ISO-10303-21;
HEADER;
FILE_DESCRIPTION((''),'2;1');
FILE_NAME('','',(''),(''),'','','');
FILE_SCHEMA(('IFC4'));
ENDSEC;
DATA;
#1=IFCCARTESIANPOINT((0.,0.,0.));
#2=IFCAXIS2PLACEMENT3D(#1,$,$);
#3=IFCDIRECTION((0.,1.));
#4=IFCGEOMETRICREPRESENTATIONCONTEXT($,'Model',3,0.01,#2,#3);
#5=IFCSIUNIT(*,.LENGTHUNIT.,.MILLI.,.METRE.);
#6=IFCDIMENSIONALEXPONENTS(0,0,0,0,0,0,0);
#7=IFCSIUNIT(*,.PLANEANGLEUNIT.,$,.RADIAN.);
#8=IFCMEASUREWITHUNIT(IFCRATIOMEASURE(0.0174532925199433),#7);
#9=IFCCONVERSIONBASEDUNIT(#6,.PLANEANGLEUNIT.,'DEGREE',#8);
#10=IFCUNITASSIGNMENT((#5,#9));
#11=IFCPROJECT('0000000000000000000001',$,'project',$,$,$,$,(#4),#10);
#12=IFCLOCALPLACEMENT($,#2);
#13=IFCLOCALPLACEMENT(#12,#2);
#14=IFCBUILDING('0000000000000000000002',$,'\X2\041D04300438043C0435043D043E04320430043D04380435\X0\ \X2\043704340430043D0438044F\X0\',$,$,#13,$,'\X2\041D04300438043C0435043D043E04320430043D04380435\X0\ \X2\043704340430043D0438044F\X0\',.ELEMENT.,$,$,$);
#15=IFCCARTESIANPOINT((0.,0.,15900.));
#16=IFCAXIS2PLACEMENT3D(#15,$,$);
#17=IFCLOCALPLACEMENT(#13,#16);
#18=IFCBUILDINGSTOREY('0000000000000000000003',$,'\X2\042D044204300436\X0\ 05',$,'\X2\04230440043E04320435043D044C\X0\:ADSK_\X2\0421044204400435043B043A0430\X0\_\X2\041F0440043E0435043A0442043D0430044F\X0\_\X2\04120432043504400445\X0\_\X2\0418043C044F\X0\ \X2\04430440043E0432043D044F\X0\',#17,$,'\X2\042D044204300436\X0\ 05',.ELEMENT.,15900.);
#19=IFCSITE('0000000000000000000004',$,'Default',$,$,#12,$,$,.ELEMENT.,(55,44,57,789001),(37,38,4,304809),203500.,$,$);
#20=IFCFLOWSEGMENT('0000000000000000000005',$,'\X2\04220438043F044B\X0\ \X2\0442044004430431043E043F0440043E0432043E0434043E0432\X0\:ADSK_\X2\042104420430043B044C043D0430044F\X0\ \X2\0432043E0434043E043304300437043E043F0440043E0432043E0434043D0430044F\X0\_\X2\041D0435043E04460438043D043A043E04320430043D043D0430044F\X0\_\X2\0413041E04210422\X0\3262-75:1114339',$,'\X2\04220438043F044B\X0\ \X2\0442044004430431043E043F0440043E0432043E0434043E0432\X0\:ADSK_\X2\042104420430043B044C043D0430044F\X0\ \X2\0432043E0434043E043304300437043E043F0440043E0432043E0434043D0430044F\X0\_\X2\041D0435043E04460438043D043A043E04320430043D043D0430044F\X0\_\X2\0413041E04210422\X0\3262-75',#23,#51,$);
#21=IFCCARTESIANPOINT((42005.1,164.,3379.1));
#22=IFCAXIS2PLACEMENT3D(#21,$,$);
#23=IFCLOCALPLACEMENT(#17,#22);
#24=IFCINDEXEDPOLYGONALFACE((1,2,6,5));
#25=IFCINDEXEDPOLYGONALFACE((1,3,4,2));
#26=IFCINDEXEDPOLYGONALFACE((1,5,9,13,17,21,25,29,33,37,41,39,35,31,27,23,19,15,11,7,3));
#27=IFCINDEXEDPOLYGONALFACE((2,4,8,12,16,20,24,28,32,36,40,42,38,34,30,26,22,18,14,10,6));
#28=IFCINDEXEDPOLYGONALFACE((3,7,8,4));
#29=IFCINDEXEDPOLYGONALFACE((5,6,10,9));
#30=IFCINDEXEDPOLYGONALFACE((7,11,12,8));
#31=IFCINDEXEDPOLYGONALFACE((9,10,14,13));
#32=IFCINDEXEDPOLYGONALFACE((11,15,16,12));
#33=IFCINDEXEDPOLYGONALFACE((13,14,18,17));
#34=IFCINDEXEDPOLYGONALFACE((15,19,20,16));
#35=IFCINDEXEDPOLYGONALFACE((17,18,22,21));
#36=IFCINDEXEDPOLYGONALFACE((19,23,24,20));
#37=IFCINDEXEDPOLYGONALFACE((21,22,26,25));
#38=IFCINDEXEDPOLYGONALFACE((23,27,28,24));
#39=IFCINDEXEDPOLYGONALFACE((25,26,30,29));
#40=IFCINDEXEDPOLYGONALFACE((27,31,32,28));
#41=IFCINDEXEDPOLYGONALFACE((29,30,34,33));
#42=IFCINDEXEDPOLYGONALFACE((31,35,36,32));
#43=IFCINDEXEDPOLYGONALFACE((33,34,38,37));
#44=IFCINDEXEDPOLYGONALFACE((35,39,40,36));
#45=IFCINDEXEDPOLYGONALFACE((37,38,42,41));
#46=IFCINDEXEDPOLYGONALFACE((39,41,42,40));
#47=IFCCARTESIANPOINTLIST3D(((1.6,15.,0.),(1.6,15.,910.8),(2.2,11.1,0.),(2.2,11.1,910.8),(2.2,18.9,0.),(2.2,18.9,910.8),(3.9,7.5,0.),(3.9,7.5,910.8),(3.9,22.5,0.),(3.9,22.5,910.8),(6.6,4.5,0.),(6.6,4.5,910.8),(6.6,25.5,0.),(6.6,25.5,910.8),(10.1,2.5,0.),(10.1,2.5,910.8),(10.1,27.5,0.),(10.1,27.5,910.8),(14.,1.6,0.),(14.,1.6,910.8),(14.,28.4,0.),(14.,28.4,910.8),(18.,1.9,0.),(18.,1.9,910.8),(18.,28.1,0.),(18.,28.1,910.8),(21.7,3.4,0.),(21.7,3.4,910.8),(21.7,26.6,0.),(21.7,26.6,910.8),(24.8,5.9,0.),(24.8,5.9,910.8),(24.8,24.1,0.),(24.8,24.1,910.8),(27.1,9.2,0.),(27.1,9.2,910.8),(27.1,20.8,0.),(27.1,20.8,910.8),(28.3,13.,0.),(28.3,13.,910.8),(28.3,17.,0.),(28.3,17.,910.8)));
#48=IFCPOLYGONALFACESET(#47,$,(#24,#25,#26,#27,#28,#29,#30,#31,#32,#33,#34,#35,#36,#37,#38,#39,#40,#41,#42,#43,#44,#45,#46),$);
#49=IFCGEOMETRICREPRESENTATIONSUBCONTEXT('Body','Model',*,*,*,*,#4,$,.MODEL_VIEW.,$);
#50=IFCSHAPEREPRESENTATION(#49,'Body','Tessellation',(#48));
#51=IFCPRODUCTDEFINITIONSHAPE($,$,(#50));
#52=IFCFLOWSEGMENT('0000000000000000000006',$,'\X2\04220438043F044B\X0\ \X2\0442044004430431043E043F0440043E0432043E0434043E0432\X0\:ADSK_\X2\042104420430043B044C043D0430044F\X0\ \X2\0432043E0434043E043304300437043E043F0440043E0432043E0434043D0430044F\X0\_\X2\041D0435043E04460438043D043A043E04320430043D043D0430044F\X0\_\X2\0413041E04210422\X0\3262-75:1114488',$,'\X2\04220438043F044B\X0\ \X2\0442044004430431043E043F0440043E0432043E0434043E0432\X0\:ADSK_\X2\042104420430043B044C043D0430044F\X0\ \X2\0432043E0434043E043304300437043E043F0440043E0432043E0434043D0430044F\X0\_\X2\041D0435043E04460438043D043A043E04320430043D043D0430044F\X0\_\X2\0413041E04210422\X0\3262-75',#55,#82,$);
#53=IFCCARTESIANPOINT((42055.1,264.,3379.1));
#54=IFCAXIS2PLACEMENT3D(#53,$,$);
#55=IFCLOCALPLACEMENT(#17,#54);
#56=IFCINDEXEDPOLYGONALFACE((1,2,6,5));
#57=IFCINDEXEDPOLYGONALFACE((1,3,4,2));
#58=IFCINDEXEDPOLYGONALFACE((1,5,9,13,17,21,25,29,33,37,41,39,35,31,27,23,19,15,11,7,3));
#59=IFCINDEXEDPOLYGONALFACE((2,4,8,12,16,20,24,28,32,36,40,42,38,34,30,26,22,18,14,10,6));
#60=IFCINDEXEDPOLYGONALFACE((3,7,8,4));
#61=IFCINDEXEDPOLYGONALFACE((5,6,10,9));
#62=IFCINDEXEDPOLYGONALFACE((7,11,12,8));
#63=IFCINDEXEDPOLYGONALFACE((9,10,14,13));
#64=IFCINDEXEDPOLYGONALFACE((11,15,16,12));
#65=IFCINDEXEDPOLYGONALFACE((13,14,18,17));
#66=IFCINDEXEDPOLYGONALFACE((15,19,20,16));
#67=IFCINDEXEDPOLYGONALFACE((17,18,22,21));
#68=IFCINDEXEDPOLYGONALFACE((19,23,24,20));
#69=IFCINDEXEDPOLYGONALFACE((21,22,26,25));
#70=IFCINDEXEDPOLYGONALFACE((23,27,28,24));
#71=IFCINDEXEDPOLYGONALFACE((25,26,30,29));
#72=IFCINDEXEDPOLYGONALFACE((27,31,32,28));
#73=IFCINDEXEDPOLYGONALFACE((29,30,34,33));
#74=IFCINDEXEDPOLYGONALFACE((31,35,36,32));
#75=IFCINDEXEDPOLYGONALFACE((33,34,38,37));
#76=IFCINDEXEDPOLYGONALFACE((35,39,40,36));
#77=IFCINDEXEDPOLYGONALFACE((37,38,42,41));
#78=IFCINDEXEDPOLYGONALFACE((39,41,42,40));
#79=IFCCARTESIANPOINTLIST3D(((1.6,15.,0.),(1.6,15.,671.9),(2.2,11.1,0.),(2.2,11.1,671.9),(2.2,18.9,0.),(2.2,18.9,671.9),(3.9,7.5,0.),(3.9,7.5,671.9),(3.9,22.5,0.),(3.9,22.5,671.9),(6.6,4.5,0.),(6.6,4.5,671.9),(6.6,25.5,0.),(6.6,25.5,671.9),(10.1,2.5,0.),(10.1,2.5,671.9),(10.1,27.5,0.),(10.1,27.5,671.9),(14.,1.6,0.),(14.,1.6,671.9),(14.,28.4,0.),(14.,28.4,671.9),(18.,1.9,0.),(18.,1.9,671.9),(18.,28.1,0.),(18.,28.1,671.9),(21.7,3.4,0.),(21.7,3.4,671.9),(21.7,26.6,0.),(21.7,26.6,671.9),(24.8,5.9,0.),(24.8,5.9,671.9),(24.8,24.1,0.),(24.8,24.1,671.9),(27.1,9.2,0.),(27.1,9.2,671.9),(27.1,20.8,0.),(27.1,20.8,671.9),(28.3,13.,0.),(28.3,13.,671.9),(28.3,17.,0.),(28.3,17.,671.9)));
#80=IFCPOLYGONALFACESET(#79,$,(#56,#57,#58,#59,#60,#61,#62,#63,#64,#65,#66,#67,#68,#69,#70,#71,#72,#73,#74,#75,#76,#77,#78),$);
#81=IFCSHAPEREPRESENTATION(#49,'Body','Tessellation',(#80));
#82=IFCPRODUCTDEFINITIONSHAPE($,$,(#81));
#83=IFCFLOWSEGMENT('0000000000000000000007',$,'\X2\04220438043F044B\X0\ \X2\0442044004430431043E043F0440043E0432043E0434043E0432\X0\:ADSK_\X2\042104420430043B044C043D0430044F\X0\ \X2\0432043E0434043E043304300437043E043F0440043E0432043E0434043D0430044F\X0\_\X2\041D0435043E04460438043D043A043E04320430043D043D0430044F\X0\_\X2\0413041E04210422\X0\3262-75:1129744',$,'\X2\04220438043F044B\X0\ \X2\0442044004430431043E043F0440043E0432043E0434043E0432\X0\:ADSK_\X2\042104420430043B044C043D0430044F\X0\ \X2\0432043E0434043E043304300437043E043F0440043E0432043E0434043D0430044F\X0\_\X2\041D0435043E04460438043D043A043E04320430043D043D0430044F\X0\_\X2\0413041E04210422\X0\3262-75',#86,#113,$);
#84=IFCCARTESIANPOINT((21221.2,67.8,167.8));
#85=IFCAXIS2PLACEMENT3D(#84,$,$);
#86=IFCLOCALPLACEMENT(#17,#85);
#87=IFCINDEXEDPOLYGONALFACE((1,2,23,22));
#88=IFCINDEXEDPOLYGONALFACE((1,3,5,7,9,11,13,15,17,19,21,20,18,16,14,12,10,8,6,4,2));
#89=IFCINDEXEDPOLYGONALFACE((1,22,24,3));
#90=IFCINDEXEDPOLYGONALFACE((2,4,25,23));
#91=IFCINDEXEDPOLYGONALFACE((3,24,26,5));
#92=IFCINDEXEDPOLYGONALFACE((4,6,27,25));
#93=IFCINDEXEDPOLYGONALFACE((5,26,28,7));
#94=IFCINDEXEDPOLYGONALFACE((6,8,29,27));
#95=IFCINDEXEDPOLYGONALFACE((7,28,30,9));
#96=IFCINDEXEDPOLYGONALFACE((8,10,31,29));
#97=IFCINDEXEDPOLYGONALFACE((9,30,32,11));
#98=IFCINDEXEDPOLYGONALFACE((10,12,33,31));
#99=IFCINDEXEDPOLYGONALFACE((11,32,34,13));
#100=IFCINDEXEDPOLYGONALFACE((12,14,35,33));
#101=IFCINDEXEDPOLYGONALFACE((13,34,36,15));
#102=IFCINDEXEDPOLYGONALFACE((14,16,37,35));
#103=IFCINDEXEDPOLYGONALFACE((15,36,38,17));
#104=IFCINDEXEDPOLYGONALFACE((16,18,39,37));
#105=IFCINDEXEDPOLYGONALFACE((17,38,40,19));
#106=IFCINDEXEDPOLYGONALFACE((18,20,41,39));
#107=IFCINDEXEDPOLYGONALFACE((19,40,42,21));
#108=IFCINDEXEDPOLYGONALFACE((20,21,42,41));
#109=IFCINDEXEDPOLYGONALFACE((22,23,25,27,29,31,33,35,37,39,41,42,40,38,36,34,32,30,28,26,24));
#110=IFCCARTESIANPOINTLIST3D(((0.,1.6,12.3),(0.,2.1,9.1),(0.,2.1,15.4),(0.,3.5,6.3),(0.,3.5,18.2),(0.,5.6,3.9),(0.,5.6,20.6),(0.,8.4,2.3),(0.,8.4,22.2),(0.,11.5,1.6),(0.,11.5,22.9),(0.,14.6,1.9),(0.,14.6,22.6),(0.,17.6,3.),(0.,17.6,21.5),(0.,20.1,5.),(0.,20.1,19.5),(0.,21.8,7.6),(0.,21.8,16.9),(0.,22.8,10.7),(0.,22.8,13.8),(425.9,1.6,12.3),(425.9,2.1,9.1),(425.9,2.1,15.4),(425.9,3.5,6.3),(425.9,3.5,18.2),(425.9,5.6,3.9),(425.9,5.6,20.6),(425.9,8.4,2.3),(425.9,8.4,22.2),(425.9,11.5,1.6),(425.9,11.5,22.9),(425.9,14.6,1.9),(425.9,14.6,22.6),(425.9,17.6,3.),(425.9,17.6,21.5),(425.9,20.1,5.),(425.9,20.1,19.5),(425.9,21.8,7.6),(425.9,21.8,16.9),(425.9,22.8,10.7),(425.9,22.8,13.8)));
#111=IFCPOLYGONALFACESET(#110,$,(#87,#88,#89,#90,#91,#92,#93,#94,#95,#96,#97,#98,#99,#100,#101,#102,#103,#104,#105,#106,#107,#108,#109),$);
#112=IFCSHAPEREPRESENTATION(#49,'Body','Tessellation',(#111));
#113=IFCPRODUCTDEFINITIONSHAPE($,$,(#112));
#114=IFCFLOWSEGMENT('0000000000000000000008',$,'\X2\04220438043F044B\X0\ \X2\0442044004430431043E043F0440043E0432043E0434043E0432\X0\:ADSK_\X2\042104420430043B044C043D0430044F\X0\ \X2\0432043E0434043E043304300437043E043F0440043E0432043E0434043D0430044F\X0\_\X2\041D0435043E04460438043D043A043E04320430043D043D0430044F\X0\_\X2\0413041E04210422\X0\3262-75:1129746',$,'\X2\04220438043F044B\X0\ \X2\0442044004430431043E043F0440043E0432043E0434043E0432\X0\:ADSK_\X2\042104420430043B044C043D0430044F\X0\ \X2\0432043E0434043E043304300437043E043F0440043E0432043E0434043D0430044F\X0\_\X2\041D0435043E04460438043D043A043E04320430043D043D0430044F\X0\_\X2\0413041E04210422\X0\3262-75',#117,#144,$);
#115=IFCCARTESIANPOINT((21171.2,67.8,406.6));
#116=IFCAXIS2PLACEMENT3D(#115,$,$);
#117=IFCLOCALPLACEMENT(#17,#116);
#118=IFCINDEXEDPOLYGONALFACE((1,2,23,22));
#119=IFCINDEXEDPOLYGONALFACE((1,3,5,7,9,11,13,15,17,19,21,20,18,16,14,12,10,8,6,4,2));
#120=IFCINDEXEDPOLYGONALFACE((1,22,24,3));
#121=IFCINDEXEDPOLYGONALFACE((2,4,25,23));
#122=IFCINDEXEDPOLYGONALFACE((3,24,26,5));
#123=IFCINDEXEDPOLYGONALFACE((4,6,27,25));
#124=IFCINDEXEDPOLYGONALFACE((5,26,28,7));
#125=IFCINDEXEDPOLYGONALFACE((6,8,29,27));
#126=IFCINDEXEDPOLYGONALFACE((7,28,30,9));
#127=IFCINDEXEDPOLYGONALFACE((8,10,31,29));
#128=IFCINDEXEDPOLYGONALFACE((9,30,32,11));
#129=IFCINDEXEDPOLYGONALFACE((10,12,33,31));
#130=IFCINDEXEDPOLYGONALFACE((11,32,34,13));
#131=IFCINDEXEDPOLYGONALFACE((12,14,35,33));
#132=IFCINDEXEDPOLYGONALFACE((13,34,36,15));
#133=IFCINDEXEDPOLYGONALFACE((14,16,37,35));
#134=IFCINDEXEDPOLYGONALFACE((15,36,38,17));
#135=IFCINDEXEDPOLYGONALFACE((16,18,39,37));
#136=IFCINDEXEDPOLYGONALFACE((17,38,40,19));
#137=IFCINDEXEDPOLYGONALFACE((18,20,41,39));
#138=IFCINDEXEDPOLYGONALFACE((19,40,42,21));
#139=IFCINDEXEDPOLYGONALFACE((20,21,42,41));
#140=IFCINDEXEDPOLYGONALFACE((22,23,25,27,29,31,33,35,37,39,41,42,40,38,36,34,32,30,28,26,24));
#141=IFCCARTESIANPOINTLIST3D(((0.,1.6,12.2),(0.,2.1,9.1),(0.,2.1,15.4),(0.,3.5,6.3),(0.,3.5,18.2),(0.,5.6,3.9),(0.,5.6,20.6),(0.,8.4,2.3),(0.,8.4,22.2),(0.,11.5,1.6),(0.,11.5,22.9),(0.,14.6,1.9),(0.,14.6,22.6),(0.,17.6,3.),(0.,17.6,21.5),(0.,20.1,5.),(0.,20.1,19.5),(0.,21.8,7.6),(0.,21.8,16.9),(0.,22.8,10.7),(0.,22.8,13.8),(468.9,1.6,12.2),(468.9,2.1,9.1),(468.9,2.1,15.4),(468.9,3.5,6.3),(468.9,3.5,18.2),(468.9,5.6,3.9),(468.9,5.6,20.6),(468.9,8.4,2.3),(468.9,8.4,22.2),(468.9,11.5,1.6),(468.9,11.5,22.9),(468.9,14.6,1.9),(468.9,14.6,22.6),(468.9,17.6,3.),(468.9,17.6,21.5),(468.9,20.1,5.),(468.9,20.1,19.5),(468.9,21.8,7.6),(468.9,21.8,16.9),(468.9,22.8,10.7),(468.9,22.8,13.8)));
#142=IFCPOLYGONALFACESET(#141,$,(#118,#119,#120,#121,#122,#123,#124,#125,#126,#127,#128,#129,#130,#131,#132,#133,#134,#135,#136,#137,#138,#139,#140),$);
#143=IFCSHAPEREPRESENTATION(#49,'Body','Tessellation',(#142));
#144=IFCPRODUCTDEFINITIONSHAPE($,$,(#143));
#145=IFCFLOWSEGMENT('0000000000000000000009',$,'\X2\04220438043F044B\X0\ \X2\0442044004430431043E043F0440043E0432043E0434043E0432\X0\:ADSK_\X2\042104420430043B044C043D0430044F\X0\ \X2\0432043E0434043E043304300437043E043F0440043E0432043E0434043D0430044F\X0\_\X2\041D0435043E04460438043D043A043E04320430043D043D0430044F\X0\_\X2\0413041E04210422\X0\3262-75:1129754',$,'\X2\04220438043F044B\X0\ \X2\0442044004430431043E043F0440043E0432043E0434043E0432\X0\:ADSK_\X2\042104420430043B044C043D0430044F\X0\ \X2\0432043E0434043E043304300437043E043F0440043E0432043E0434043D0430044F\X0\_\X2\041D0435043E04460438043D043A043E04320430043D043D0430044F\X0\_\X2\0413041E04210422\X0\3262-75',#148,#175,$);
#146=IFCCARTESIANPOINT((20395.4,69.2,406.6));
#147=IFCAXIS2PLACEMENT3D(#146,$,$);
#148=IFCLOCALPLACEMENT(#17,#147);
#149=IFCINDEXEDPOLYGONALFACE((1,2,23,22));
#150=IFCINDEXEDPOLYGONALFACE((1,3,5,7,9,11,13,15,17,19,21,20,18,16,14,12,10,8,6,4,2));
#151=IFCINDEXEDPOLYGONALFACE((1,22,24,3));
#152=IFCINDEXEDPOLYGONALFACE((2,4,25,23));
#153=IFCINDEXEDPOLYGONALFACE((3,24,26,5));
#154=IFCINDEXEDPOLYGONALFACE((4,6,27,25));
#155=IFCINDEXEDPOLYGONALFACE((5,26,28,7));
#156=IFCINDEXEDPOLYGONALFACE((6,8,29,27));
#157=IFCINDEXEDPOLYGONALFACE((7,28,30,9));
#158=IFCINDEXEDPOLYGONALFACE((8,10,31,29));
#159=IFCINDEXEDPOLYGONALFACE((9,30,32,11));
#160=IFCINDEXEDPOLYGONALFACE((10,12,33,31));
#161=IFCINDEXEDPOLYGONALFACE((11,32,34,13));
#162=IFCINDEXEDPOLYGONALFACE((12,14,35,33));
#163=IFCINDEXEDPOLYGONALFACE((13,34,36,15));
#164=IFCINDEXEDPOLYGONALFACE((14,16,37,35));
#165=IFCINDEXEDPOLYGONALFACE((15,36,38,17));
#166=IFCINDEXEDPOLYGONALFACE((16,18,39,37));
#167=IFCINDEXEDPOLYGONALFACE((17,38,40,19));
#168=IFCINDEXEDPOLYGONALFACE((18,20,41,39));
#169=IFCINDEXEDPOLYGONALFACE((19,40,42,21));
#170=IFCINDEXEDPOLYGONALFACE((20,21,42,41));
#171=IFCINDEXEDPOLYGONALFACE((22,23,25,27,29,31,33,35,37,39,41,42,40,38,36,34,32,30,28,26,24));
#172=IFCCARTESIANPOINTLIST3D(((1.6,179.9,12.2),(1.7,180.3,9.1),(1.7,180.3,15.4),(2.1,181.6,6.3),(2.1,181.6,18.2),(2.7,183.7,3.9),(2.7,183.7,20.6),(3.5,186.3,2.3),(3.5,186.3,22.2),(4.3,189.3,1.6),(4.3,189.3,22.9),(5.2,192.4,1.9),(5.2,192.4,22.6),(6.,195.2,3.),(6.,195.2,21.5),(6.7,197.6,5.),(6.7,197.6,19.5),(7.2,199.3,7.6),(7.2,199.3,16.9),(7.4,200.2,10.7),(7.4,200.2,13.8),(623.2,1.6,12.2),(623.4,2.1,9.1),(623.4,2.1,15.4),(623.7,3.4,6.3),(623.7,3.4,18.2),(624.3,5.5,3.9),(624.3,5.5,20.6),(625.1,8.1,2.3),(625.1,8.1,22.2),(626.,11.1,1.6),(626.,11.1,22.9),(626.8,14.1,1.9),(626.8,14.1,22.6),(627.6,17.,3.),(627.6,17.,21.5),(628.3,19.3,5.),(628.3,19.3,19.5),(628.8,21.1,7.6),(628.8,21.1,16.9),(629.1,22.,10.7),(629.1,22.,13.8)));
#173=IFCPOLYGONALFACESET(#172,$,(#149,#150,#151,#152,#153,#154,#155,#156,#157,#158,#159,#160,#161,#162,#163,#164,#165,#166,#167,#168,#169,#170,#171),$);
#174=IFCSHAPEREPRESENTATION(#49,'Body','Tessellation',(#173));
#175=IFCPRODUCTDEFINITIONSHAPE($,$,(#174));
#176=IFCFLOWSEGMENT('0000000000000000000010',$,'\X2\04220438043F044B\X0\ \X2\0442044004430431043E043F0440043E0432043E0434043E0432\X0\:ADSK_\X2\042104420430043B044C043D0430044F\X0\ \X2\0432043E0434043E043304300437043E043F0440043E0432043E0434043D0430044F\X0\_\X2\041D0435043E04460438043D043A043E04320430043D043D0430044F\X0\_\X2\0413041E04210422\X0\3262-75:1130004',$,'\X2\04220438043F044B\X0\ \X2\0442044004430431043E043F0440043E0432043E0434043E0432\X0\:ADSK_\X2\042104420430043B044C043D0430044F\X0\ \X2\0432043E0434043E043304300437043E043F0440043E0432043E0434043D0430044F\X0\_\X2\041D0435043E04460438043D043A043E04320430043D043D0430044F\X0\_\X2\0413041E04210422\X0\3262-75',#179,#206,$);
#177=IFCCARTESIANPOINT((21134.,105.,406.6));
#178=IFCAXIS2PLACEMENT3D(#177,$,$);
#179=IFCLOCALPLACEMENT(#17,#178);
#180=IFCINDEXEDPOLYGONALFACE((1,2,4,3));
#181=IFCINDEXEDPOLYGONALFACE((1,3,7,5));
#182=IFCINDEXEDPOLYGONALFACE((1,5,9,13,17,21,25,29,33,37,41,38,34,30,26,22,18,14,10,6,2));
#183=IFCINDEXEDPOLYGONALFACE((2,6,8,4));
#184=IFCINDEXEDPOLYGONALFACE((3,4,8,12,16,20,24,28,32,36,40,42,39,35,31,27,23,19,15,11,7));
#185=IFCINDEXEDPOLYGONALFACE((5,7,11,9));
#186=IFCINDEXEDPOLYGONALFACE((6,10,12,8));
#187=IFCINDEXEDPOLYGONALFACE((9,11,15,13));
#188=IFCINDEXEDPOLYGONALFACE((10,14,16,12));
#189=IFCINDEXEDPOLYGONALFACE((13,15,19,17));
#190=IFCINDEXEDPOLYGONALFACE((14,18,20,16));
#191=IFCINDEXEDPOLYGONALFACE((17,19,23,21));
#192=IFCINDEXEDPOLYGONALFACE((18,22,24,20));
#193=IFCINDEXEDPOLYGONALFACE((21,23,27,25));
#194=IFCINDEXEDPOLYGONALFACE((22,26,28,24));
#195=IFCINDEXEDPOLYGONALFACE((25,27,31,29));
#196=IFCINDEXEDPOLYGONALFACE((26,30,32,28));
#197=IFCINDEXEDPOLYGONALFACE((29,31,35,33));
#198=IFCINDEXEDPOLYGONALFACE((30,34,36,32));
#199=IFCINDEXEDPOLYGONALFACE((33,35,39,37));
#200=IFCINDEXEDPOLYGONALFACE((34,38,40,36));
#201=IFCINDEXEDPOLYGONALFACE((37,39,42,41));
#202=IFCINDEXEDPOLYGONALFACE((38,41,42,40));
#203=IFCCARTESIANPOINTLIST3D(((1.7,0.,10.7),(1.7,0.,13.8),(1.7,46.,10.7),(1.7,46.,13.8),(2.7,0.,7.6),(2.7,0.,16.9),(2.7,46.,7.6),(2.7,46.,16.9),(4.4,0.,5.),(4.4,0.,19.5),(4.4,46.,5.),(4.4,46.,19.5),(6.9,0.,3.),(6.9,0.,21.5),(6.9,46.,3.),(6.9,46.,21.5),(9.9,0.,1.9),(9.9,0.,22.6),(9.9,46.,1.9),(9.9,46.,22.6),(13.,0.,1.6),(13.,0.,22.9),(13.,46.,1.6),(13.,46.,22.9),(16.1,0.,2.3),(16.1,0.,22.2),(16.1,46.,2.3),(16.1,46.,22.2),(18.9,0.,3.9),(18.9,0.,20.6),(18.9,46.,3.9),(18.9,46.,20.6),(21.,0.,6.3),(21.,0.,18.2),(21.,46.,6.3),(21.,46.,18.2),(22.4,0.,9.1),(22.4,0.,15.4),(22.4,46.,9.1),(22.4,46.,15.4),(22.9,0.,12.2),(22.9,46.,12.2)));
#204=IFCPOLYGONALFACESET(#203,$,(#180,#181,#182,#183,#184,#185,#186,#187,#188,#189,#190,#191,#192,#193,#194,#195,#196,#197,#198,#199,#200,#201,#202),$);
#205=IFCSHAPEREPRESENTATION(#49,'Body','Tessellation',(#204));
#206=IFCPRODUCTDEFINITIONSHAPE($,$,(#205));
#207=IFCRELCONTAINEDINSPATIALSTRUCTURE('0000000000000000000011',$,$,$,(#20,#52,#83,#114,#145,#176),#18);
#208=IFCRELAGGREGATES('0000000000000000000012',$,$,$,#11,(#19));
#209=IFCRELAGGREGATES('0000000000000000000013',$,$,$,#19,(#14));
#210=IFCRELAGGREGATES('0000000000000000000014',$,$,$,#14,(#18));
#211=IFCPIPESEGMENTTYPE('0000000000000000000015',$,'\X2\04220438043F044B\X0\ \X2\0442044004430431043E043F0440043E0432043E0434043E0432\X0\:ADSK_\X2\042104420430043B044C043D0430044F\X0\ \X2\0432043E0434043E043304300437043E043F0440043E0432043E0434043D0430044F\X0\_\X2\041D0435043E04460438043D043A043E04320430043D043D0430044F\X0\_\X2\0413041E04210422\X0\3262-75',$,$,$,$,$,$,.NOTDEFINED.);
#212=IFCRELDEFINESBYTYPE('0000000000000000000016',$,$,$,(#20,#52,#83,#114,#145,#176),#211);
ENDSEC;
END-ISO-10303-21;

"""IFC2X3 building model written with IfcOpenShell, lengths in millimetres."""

from ifc_helpers import new_model, entity, si_unit, converted_unit, direction, frame, origin, origin_2d_with_axis, place, context, subcontext, project, spatial, circle, extrude, type_object, element, save


model = new_model("IFC2X3")

# Units and contexts
model_context = context("Model", 3, precision=0.01, world=origin(), true_north=direction((0.0, 1.0)))
body_context = subcontext(model_context, "Body", "Model", "MODEL_VIEW")
ifc_project = project(units=[si_unit("LENGTHUNIT", "METRE", prefix="MILLI"), converted_unit("PLANEANGLEUNIT", "DEGREE", entity("IfcRatioMeasure", 0.0174532925199433), si_unit("PLANEANGLEUNIT", "RADIAN"), dimensions=[0, 0, 0, 0, 0, 0, 0])], contexts=[model_context])

# Site, building, storey
site_placement = place(None, origin())
site = spatial("IfcSite", under=ifc_project, at=site_placement, Name="Default", CompositionType="ELEMENT", RefLatitude=(55, 44, 57, 789001), RefLongitude=(37, 38, 4, 304809), RefElevation=203500.0)
building_placement = place(site_placement, origin())
building = spatial("IfcBuilding", under=site, at=building_placement, Name="Наименование здания", LongName="Наименование здания", CompositionType="ELEMENT")
storey_placement = place(building_placement, frame((0.0, 0.0, 15900.0)))
storey = spatial("IfcBuildingStorey", under=building, at=storey_placement, Name="Этаж 05", ObjectType="Уровень:ADSK_Стрелка_Проектная_Вверх_Имя уровня", LongName="Этаж 05", CompositionType="ELEMENT", Elevation=15900.0)

# Flow segments
pipe_segment_type = type_object("IfcPipeSegmentType", Name="Типы трубопроводов:ADSK_Стальная водогазопроводная_Неоцинкованная_ГОСТ3262-75", PredefinedType="NOTDEFINED")
flow_segment_1_placement = place(storey_placement, frame((42005.1, 164.0, 3379.1)))
element("IfcFlowSegment", 1, at=flow_segment_1_placement, inside=storey, type_object=pipe_segment_type, Name="Типы трубопроводов:ADSK_Стальная водогазопроводная_Неоцинкованная_ГОСТ3262-75:1114339", ObjectType="Типы трубопроводов:ADSK_Стальная водогазопроводная_Неоцинкованная_ГОСТ3262-75", context=body_context, shape_type="SweptSolid", body=[
    extrude(circle(Radius=13.4, at=origin_2d_with_axis()), frame((15.0, 15.0, 0.0), z_axis=(0.0, 0.0, 1.0), x_axis=(-1.0, 0.0, 0.0)), (0.0, 0.0, 1.0), 910.8),
])
flow_segment_2_placement = place(storey_placement, frame((42055.1, 264.0, 3379.1)))
element("IfcFlowSegment", 2, at=flow_segment_2_placement, inside=storey, type_object=pipe_segment_type, Name="Типы трубопроводов:ADSK_Стальная водогазопроводная_Неоцинкованная_ГОСТ3262-75:1114488", ObjectType="Типы трубопроводов:ADSK_Стальная водогазопроводная_Неоцинкованная_ГОСТ3262-75", context=body_context, shape_type="SweptSolid", body=[
    extrude(circle(Radius=13.4, at=origin_2d_with_axis()), frame((15.0, 15.0, 0.0), z_axis=(0.0, 0.0, 1.0), x_axis=(-1.0, 0.0, 0.0)), (0.0, 0.0, 1.0), 671.9),
])
flow_segment_3_placement = place(storey_placement, frame((21221.2, 67.8, 167.8)))
element("IfcFlowSegment", 3, at=flow_segment_3_placement, inside=storey, type_object=pipe_segment_type, Name="Типы трубопроводов:ADSK_Стальная водогазопроводная_Неоцинкованная_ГОСТ3262-75:1129744", ObjectType="Типы трубопроводов:ADSK_Стальная водогазопроводная_Неоцинкованная_ГОСТ3262-75", context=body_context, shape_type="SweptSolid", body=[
    extrude(circle(Radius=10.7, at=origin_2d_with_axis()), frame((0.0, 12.2, 12.2), z_axis=(1.0, 0.0, 0.0), x_axis=(0.0, -1.0, 0.0)), (0.0, 0.0, 1.0), 425.9),
])
flow_segment_4_placement = place(storey_placement, frame((21171.2, 67.8, 406.6)))
element("IfcFlowSegment", 4, at=flow_segment_4_placement, inside=storey, type_object=pipe_segment_type, Name="Типы трубопроводов:ADSK_Стальная водогазопроводная_Неоцинкованная_ГОСТ3262-75:1129746", ObjectType="Типы трубопроводов:ADSK_Стальная водогазопроводная_Неоцинкованная_ГОСТ3262-75", context=body_context, shape_type="SweptSolid", body=[
    extrude(circle(Radius=10.7, at=origin_2d_with_axis()), frame((0.0, 12.2, 12.2), z_axis=(1.0, 0.0, 0.0), x_axis=(0.0, -1.0, 0.0)), (0.0, 0.0, 1.0), 468.9),
])
flow_segment_5_placement = place(storey_placement, frame((20395.4, 69.2, 406.6)))
element("IfcFlowSegment", 5, at=flow_segment_5_placement, inside=storey, type_object=pipe_segment_type, Name="Типы трубопроводов:ADSK_Стальная водогазопроводная_Неоцинкованная_ГОСТ3262-75:1129754", ObjectType="Типы трубопроводов:ADSK_Стальная водогазопроводная_Неоцинкованная_ГОСТ3262-75", context=body_context, shape_type="SweptSolid", body=[
    extrude(circle(Radius=10.7, at=origin_2d_with_axis()), frame((4.5, 190.1, 12.2), z_axis=(0.961262, -0.275637, 0.0), x_axis=(-0.275637, -0.961262, 0.0)), (0.0, 0.0, 1.0), 646.7),
])
flow_segment_6_placement = place(storey_placement, frame((21134.0, 105.0, 406.6)))
element("IfcFlowSegment", 6, at=flow_segment_6_placement, inside=storey, type_object=pipe_segment_type, Name="Типы трубопроводов:ADSK_Стальная водогазопроводная_Неоцинкованная_ГОСТ3262-75:1130004", ObjectType="Типы трубопроводов:ADSK_Стальная водогазопроводная_Неоцинкованная_ГОСТ3262-75", context=body_context, shape_type="SweptSolid", body=[
    extrude(circle(Radius=10.7, at=origin_2d_with_axis()), frame((12.2, 0.0, 12.2), z_axis=(0.0, 1.0, 0.0), x_axis=(1.0, 0.0, 0.0)), (0.0, 0.0, 1.0), 46.0),
])

save(model, "model.ifc")
